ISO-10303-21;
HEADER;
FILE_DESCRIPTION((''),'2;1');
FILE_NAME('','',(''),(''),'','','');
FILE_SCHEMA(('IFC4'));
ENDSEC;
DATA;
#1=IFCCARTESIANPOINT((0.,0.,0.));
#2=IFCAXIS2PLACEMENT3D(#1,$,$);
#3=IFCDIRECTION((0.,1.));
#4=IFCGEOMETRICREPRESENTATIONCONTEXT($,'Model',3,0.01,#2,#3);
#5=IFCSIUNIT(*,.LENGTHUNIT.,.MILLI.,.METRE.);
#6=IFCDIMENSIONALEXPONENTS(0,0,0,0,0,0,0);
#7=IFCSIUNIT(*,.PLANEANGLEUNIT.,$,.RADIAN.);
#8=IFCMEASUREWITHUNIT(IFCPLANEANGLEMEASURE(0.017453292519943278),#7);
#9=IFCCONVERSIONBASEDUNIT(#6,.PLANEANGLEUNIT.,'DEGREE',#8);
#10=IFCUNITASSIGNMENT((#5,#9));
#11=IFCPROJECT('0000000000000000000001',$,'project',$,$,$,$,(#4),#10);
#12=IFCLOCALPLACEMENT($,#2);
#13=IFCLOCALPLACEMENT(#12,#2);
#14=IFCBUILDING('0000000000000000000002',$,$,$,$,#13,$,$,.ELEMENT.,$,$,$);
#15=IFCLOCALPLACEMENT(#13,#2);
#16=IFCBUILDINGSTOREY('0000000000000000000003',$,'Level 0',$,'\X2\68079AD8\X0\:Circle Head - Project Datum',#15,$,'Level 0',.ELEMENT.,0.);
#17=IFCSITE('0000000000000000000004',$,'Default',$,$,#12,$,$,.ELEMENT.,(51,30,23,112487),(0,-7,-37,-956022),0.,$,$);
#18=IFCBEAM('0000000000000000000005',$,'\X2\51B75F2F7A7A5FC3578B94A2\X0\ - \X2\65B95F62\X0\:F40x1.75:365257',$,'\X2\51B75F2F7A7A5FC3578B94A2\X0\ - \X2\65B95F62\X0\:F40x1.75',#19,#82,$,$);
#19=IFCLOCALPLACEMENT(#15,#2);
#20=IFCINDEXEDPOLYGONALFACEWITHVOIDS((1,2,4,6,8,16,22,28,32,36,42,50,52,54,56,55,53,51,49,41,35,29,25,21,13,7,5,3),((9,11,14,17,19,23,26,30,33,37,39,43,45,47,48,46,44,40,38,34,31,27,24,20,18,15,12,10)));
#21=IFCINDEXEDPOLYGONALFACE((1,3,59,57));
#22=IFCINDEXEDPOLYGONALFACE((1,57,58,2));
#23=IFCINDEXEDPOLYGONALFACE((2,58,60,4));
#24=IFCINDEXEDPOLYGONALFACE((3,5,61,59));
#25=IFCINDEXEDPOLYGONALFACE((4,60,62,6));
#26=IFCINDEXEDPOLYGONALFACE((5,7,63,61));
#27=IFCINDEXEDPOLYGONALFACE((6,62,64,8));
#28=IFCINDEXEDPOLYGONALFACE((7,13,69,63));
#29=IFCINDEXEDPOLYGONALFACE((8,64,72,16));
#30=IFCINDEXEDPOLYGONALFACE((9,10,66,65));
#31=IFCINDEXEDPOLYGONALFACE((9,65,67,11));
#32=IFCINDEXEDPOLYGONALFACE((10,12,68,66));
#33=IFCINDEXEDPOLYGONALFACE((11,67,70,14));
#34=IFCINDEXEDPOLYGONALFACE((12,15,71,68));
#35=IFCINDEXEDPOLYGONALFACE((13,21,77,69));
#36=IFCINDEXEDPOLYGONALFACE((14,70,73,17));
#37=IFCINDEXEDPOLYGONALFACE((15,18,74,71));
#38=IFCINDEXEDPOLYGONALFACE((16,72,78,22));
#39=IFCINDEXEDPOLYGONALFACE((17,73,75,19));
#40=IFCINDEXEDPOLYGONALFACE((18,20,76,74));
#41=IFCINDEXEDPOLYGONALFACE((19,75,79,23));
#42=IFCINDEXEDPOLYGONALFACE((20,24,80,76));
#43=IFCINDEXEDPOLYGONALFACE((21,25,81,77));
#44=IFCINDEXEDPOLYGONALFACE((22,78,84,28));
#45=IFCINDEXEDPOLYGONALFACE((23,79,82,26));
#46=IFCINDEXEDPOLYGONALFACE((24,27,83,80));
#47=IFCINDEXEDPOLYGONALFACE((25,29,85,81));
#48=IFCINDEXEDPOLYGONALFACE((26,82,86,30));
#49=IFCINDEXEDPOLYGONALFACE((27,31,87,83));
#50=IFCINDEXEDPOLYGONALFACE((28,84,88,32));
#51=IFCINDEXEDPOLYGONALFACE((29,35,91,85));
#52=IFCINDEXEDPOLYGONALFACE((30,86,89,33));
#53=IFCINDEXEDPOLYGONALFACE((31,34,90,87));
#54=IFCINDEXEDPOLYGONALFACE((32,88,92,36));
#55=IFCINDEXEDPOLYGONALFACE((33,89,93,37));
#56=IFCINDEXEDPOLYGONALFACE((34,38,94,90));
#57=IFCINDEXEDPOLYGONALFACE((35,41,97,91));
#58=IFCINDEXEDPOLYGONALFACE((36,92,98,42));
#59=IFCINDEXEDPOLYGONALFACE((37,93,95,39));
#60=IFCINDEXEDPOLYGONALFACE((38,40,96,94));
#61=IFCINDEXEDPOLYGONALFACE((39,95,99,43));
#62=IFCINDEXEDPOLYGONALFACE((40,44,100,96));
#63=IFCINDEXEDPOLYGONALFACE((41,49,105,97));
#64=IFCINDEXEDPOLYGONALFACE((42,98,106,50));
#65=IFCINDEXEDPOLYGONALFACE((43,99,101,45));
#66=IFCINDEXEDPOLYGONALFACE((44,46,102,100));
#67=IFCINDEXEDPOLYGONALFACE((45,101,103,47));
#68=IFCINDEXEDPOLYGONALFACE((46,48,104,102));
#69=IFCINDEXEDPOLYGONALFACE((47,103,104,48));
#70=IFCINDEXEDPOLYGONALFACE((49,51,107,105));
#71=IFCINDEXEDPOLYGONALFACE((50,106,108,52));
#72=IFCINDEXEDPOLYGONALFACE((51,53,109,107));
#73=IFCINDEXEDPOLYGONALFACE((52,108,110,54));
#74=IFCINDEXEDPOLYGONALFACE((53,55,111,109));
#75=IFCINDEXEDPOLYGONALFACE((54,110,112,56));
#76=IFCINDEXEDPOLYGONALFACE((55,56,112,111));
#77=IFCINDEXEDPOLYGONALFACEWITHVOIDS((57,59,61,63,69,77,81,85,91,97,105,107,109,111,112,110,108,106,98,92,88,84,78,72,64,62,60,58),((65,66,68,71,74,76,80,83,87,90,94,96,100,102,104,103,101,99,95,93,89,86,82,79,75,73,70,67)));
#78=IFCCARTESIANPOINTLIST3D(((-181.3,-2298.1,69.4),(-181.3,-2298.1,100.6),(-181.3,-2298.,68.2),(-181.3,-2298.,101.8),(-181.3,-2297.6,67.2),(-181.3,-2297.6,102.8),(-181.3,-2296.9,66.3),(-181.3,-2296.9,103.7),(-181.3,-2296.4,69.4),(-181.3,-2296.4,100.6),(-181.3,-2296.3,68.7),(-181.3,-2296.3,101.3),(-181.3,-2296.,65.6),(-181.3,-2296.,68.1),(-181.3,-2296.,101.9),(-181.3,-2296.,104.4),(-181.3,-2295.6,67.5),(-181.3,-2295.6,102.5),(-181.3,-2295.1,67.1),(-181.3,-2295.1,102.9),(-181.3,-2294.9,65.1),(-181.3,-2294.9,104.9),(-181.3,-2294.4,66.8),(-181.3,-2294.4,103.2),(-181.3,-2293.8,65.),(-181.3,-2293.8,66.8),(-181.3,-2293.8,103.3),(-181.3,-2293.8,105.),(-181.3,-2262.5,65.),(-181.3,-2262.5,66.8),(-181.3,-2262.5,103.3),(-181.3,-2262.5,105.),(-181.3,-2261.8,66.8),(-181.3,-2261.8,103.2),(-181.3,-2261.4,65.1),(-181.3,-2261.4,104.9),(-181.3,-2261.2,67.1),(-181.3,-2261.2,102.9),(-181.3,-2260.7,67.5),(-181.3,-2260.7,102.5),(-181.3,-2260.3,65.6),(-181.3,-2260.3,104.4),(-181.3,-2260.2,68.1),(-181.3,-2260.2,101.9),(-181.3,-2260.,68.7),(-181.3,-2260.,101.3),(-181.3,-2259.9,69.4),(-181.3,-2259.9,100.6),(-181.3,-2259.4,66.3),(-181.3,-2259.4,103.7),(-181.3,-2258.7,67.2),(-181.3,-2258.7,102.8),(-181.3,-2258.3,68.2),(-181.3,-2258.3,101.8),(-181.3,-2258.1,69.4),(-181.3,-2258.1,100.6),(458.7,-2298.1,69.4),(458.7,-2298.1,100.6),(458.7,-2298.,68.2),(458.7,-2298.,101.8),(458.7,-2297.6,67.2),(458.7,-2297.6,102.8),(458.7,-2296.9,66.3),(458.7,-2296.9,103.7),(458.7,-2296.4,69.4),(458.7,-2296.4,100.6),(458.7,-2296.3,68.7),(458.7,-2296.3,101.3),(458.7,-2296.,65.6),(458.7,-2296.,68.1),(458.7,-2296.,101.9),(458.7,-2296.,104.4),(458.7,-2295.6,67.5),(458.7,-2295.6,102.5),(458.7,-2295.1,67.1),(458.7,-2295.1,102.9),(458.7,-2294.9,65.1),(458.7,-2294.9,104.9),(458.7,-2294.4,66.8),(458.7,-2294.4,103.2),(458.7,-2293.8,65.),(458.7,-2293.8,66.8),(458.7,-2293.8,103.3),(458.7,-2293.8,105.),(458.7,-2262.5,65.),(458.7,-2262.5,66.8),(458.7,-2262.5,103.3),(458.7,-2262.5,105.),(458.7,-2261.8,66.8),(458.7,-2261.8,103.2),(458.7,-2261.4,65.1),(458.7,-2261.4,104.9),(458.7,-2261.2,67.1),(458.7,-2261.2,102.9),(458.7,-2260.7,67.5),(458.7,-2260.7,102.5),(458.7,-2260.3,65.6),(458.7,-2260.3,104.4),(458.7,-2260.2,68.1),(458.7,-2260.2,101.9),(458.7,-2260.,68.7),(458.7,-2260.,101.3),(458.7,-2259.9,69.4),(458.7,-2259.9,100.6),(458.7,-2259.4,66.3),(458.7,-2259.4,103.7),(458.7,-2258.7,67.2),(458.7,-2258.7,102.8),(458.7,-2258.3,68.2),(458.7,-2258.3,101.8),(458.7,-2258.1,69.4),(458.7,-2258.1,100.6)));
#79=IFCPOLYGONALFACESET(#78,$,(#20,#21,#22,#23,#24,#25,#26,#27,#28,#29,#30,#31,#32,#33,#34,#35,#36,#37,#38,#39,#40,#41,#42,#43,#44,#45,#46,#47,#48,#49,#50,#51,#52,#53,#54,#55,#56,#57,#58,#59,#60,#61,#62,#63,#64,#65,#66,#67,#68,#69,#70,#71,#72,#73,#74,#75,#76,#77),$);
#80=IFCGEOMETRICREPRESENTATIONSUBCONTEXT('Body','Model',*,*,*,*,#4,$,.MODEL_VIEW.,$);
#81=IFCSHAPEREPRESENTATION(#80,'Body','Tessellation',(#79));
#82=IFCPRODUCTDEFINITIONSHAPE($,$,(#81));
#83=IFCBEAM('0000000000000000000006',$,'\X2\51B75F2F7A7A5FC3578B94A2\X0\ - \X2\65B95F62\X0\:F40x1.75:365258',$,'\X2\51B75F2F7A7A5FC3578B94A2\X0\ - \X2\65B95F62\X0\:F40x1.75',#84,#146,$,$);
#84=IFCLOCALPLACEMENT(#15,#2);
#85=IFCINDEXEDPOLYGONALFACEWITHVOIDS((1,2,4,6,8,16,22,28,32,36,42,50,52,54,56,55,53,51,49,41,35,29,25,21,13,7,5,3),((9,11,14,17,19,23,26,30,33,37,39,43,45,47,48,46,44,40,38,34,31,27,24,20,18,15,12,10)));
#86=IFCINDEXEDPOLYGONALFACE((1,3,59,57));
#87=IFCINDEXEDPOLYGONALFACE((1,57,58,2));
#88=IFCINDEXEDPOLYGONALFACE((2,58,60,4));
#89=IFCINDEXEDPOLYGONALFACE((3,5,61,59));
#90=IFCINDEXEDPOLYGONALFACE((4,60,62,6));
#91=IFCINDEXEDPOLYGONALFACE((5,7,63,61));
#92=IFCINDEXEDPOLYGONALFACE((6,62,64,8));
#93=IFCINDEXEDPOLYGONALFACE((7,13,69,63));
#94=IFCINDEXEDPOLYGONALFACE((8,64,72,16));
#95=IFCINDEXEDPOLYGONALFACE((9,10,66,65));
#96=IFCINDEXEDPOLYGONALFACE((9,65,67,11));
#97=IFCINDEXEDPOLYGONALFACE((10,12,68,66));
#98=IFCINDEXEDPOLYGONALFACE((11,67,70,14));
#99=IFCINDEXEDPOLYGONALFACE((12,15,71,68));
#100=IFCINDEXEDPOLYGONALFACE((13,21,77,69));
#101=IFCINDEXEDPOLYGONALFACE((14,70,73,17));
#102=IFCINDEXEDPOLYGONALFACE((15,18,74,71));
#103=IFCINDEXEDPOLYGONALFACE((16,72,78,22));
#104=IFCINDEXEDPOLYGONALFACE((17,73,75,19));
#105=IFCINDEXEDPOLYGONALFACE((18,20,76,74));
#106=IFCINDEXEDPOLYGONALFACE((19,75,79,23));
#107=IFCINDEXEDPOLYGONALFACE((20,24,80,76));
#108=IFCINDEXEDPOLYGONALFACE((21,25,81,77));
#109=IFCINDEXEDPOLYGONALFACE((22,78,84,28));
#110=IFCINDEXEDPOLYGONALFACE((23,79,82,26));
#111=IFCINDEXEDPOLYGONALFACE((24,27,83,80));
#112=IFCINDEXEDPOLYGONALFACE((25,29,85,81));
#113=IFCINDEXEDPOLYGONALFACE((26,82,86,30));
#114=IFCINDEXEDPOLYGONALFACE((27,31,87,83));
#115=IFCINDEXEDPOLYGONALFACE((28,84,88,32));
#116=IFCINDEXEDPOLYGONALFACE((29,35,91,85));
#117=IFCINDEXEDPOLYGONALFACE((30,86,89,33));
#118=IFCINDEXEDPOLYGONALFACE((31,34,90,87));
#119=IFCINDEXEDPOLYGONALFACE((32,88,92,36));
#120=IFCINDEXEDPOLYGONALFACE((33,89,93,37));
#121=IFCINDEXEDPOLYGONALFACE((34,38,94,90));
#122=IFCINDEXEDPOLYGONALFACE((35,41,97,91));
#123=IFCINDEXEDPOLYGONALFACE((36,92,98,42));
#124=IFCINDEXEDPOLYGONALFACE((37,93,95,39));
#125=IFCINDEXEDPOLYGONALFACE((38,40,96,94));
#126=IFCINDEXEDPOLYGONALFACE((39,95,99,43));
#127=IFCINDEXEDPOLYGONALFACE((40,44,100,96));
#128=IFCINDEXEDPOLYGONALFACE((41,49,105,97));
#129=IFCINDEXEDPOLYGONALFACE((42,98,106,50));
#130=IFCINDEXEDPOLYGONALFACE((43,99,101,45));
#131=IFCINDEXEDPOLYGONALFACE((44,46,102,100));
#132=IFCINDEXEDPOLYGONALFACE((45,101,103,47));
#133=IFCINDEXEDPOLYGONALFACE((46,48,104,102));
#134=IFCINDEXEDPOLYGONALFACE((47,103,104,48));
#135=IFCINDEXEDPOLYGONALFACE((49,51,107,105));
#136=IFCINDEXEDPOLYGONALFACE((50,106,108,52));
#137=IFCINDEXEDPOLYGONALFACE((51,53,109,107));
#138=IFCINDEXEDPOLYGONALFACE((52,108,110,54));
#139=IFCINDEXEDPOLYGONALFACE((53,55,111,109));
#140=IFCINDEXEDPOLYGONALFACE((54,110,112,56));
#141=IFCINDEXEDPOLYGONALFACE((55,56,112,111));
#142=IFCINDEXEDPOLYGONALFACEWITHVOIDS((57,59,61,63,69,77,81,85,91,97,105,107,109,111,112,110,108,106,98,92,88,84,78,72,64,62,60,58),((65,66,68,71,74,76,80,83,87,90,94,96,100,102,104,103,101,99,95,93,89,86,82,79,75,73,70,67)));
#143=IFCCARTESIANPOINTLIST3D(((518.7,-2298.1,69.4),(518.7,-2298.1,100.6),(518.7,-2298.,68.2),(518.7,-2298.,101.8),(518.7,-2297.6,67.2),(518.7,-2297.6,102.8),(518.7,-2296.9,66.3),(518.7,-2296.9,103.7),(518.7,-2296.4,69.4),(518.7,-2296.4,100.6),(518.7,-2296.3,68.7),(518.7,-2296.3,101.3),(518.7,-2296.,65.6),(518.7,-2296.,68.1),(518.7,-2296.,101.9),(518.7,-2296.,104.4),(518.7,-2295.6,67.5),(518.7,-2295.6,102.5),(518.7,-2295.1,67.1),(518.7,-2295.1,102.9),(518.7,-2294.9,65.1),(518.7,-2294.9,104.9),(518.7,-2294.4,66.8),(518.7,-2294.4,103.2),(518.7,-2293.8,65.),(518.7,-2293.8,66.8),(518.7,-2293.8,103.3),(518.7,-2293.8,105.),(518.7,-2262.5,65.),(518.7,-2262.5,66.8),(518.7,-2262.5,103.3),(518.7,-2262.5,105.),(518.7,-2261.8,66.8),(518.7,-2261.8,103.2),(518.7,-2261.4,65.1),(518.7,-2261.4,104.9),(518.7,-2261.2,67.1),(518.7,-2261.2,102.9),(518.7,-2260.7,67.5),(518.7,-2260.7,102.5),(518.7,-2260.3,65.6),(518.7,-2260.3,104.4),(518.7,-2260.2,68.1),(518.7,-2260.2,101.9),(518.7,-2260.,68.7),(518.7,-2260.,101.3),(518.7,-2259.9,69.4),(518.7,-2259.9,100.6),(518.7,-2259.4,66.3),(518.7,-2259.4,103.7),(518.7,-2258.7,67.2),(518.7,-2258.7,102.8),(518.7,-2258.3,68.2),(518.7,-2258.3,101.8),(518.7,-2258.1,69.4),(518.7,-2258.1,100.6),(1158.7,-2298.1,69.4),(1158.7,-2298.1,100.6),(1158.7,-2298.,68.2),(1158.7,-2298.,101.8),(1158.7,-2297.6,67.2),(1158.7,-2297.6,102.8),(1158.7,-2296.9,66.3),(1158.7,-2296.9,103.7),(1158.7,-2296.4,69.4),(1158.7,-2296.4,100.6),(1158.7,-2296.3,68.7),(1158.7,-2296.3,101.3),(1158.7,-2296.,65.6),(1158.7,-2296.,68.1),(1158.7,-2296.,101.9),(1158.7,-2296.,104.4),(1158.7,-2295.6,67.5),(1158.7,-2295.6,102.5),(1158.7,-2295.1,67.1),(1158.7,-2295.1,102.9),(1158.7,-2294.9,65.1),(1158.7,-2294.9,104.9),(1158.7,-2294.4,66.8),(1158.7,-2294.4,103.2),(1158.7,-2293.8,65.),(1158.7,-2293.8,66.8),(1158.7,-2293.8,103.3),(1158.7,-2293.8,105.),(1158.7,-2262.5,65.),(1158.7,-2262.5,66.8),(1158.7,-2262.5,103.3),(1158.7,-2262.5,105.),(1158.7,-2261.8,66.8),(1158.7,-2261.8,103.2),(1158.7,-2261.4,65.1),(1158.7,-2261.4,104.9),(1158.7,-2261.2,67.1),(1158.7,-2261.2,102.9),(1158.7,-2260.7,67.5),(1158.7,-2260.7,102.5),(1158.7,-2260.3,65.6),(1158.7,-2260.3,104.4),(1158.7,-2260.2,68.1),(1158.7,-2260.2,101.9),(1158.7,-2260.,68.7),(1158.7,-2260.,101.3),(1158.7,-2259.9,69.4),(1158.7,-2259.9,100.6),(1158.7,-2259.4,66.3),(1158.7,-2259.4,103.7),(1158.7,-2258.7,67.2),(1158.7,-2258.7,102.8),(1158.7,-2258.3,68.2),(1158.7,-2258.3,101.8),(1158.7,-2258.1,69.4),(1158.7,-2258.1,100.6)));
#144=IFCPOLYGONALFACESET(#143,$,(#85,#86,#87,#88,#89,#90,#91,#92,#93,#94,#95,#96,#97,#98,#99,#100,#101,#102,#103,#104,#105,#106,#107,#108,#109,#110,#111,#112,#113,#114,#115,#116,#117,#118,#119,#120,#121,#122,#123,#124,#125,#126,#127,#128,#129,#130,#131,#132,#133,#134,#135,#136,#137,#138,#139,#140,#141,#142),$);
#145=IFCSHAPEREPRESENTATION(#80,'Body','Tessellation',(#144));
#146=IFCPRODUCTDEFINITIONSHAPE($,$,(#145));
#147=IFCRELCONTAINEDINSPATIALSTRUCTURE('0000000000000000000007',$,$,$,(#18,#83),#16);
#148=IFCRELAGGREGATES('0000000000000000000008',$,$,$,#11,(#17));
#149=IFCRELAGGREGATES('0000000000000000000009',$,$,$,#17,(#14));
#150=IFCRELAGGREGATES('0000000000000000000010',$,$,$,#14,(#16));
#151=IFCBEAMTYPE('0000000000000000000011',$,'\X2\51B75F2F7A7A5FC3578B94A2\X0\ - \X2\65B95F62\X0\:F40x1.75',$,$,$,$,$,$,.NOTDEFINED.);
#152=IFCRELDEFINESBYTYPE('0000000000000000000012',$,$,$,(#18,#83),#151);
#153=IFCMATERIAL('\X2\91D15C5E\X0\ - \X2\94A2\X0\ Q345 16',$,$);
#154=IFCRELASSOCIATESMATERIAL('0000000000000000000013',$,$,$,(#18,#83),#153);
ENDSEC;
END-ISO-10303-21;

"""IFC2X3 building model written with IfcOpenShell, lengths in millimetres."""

from ifc_helpers import new_model, entity, si_unit, converted_unit, direction, frame, frame_2d, origin, place, context, subcontext, project, spatial, polyline, circle_curve, parameter, trimmed, segment, composite_curve, outline, extrude, material, type_object, element, save


model = new_model("IFC2X3")

# Units and contexts
model_context = context("Model", 3, precision=0.01, world=origin(), true_north=direction((0.0, 1.0)))
body_context = subcontext(model_context, "Body", "Model", "MODEL_VIEW")
ifc_project = project(units=[si_unit("LENGTHUNIT", "METRE", prefix="MILLI"), converted_unit("PLANEANGLEUNIT", "DEGREE", entity("IfcPlaneAngleMeasure", 0.017453292519943278), si_unit("PLANEANGLEUNIT", "RADIAN"), dimensions=[0, 0, 0, 0, 0, 0, 0])], contexts=[model_context])

# Site, building, storey
site_placement = place(None, origin())
site = spatial("IfcSite", under=ifc_project, at=site_placement, Name="Default", CompositionType="ELEMENT", RefLatitude=(51, 30, 23, 112487), RefLongitude=(0, -7, -37, -956022), RefElevation=0.0)
building_placement = place(site_placement, origin())
building = spatial("IfcBuilding", under=site, at=building_placement, CompositionType="ELEMENT")
storey_placement = place(building_placement, origin())
storey = spatial("IfcBuildingStorey", under=building, at=storey_placement, Name="Level 0", ObjectType="标高:Circle Head - Project Datum", LongName="Level 0", CompositionType="ELEMENT", Elevation=0.0)

# Beams
ifc_material_1 = material(Name="金属 - 钢 Q345 16")
beam_type_1 = type_object("IfcBeamType", Name="冷弯空心型钢 - 方形:F40x1.75", PredefinedType="NOTDEFINED")
beam_1_placement = place(storey_placement, frame((323.7, -2278.1, 105.0), z_axis=(0.0, 0.0, 1.0), x_axis=(-1.0, 0.0, 0.0)))
element("IfcBeam", 1, at=beam_1_placement, inside=storey, type_object=beam_type_1, material=ifc_material_1, Name="冷弯空心型钢 - 方形:F40x1.75:365257", ObjectType="冷弯空心型钢 - 方形:F40x1.75", context=body_context, shape_type="SweptSolid", body=[
    extrude(outline(composite_curve([segment(trimmed(circle_curve(frame_2d((-15.6, 15.6), x_axis=(1.0, 0.0)), 4.4), [parameter(90.0)], [parameter(180.0)], True, "PARAMETER"), True, "CONTINUOUS"), segment(polyline([(-20.0, 15.6), (-20.0, -15.6)]), True, "CONTINUOUS"), segment(trimmed(circle_curve(frame_2d((-15.6, -15.6), x_axis=(1.0, 0.0)), 4.4), [parameter(180.0)], [parameter(270.0)], True, "PARAMETER"), True, "CONTINUOUS"), segment(polyline([(-15.6, -20.0), (15.6, -20.0)]), True, "CONTINUOUS"), segment(trimmed(circle_curve(frame_2d((15.6, -15.6), x_axis=(1.0, 0.0)), 4.4), [parameter(270.0)], [parameter(0.0)], True, "PARAMETER"), True, "CONTINUOUS"), segment(polyline([(20.0, -15.6), (20.0, 15.6)]), True, "CONTINUOUS"), segment(trimmed(circle_curve(frame_2d((15.6, 15.6), x_axis=(1.0, 0.0)), 4.4), [parameter(0.0)], [parameter(90.0)], True, "PARAMETER"), True, "CONTINUOUS"), segment(polyline([(15.6, 20.0), (-15.6, 20.0)]), True, "CONTINUOUS")], self_intersect=False), holes=[composite_curve([segment(polyline([(-15.6, 18.3), (15.6, 18.3)]), True, "CONTINUOUS"), segment(trimmed(circle_curve(frame_2d((15.6, 15.6), x_axis=(1.0, 0.0)), 2.6), [parameter(0.0)], [parameter(90.0)], True, "PARAMETER"), False, "CONTINUOUS"), segment(polyline([(18.2, 15.6), (18.2, -15.6)]), True, "CONTINUOUS"), segment(trimmed(circle_curve(frame_2d((15.6, -15.6), x_axis=(1.0, 0.0)), 2.6), [parameter(270.0)], [parameter(360.0)], True, "PARAMETER"), False, "CONTINUOUS"), segment(polyline([(15.6, -18.2), (-15.6, -18.2)]), True, "CONTINUOUS"), segment(trimmed(circle_curve(frame_2d((-15.6, -15.6), x_axis=(1.0, 0.0)), 2.6), [parameter(180.0)], [parameter(270.0)], True, "PARAMETER"), False, "CONTINUOUS"), segment(polyline([(-18.3, -15.6), (-18.3, 15.6)]), True, "CONTINUOUS"), segment(trimmed(circle_curve(frame_2d((-15.6, 15.6), x_axis=(1.0, 0.0)), 2.6), [parameter(90.0)], [parameter(180.0)], True, "PARAMETER"), False, "CONTINUOUS")], self_intersect=False)]), frame((-135.0, 0.0, -20.0), z_axis=(1.0, 0.0, 0.0), x_axis=(0.0, 1.0, 0.0)), (0.0, 0.0, 1.0), 640.0),
])
beam_2_placement = place(storey_placement, frame((1023.7, -2278.1, 105.0), z_axis=(0.0, 0.0, 1.0), x_axis=(-1.0, 0.0, 0.0)))
element("IfcBeam", 2, at=beam_2_placement, inside=storey, type_object=beam_type_1, material=ifc_material_1, Name="冷弯空心型钢 - 方形:F40x1.75:365258", ObjectType="冷弯空心型钢 - 方形:F40x1.75", context=body_context, shape_type="SweptSolid", body=[
    extrude(outline(composite_curve([segment(trimmed(circle_curve(frame_2d((-15.6, 15.6), x_axis=(1.0, 0.0)), 4.4), [parameter(90.0)], [parameter(180.0)], True, "PARAMETER"), True, "CONTINUOUS"), segment(polyline([(-20.0, 15.6), (-20.0, -15.6)]), True, "CONTINUOUS"), segment(trimmed(circle_curve(frame_2d((-15.6, -15.6), x_axis=(1.0, 0.0)), 4.4), [parameter(180.0)], [parameter(270.0)], True, "PARAMETER"), True, "CONTINUOUS"), segment(polyline([(-15.6, -20.0), (15.6, -20.0)]), True, "CONTINUOUS"), segment(trimmed(circle_curve(frame_2d((15.6, -15.6), x_axis=(1.0, 0.0)), 4.4), [parameter(270.0)], [parameter(0.0)], True, "PARAMETER"), True, "CONTINUOUS"), segment(polyline([(20.0, -15.6), (20.0, 15.6)]), True, "CONTINUOUS"), segment(trimmed(circle_curve(frame_2d((15.6, 15.6), x_axis=(1.0, 0.0)), 4.4), [parameter(0.0)], [parameter(90.0)], True, "PARAMETER"), True, "CONTINUOUS"), segment(polyline([(15.6, 20.0), (-15.6, 20.0)]), True, "CONTINUOUS")], self_intersect=False), holes=[composite_curve([segment(polyline([(-15.6, 18.3), (15.6, 18.3)]), True, "CONTINUOUS"), segment(trimmed(circle_curve(frame_2d((15.6, 15.6), x_axis=(1.0, 0.0)), 2.6), [parameter(0.0)], [parameter(90.0)], True, "PARAMETER"), False, "CONTINUOUS"), segment(polyline([(18.2, 15.6), (18.2, -15.6)]), True, "CONTINUOUS"), segment(trimmed(circle_curve(frame_2d((15.6, -15.6), x_axis=(1.0, 0.0)), 2.6), [parameter(270.0)], [parameter(360.0)], True, "PARAMETER"), False, "CONTINUOUS"), segment(polyline([(15.6, -18.2), (-15.6, -18.2)]), True, "CONTINUOUS"), segment(trimmed(circle_curve(frame_2d((-15.6, -15.6), x_axis=(1.0, 0.0)), 2.6), [parameter(180.0)], [parameter(270.0)], True, "PARAMETER"), False, "CONTINUOUS"), segment(polyline([(-18.3, -15.6), (-18.3, 15.6)]), True, "CONTINUOUS"), segment(trimmed(circle_curve(frame_2d((-15.6, 15.6), x_axis=(1.0, 0.0)), 2.6), [parameter(90.0)], [parameter(180.0)], True, "PARAMETER"), False, "CONTINUOUS")], self_intersect=False)]), frame((-135.0, 0.0, -20.0), z_axis=(1.0, 0.0, 0.0), x_axis=(0.0, 1.0, 0.0)), (0.0, 0.0, 1.0), 640.0),
])

save(model, "model.ifc")
